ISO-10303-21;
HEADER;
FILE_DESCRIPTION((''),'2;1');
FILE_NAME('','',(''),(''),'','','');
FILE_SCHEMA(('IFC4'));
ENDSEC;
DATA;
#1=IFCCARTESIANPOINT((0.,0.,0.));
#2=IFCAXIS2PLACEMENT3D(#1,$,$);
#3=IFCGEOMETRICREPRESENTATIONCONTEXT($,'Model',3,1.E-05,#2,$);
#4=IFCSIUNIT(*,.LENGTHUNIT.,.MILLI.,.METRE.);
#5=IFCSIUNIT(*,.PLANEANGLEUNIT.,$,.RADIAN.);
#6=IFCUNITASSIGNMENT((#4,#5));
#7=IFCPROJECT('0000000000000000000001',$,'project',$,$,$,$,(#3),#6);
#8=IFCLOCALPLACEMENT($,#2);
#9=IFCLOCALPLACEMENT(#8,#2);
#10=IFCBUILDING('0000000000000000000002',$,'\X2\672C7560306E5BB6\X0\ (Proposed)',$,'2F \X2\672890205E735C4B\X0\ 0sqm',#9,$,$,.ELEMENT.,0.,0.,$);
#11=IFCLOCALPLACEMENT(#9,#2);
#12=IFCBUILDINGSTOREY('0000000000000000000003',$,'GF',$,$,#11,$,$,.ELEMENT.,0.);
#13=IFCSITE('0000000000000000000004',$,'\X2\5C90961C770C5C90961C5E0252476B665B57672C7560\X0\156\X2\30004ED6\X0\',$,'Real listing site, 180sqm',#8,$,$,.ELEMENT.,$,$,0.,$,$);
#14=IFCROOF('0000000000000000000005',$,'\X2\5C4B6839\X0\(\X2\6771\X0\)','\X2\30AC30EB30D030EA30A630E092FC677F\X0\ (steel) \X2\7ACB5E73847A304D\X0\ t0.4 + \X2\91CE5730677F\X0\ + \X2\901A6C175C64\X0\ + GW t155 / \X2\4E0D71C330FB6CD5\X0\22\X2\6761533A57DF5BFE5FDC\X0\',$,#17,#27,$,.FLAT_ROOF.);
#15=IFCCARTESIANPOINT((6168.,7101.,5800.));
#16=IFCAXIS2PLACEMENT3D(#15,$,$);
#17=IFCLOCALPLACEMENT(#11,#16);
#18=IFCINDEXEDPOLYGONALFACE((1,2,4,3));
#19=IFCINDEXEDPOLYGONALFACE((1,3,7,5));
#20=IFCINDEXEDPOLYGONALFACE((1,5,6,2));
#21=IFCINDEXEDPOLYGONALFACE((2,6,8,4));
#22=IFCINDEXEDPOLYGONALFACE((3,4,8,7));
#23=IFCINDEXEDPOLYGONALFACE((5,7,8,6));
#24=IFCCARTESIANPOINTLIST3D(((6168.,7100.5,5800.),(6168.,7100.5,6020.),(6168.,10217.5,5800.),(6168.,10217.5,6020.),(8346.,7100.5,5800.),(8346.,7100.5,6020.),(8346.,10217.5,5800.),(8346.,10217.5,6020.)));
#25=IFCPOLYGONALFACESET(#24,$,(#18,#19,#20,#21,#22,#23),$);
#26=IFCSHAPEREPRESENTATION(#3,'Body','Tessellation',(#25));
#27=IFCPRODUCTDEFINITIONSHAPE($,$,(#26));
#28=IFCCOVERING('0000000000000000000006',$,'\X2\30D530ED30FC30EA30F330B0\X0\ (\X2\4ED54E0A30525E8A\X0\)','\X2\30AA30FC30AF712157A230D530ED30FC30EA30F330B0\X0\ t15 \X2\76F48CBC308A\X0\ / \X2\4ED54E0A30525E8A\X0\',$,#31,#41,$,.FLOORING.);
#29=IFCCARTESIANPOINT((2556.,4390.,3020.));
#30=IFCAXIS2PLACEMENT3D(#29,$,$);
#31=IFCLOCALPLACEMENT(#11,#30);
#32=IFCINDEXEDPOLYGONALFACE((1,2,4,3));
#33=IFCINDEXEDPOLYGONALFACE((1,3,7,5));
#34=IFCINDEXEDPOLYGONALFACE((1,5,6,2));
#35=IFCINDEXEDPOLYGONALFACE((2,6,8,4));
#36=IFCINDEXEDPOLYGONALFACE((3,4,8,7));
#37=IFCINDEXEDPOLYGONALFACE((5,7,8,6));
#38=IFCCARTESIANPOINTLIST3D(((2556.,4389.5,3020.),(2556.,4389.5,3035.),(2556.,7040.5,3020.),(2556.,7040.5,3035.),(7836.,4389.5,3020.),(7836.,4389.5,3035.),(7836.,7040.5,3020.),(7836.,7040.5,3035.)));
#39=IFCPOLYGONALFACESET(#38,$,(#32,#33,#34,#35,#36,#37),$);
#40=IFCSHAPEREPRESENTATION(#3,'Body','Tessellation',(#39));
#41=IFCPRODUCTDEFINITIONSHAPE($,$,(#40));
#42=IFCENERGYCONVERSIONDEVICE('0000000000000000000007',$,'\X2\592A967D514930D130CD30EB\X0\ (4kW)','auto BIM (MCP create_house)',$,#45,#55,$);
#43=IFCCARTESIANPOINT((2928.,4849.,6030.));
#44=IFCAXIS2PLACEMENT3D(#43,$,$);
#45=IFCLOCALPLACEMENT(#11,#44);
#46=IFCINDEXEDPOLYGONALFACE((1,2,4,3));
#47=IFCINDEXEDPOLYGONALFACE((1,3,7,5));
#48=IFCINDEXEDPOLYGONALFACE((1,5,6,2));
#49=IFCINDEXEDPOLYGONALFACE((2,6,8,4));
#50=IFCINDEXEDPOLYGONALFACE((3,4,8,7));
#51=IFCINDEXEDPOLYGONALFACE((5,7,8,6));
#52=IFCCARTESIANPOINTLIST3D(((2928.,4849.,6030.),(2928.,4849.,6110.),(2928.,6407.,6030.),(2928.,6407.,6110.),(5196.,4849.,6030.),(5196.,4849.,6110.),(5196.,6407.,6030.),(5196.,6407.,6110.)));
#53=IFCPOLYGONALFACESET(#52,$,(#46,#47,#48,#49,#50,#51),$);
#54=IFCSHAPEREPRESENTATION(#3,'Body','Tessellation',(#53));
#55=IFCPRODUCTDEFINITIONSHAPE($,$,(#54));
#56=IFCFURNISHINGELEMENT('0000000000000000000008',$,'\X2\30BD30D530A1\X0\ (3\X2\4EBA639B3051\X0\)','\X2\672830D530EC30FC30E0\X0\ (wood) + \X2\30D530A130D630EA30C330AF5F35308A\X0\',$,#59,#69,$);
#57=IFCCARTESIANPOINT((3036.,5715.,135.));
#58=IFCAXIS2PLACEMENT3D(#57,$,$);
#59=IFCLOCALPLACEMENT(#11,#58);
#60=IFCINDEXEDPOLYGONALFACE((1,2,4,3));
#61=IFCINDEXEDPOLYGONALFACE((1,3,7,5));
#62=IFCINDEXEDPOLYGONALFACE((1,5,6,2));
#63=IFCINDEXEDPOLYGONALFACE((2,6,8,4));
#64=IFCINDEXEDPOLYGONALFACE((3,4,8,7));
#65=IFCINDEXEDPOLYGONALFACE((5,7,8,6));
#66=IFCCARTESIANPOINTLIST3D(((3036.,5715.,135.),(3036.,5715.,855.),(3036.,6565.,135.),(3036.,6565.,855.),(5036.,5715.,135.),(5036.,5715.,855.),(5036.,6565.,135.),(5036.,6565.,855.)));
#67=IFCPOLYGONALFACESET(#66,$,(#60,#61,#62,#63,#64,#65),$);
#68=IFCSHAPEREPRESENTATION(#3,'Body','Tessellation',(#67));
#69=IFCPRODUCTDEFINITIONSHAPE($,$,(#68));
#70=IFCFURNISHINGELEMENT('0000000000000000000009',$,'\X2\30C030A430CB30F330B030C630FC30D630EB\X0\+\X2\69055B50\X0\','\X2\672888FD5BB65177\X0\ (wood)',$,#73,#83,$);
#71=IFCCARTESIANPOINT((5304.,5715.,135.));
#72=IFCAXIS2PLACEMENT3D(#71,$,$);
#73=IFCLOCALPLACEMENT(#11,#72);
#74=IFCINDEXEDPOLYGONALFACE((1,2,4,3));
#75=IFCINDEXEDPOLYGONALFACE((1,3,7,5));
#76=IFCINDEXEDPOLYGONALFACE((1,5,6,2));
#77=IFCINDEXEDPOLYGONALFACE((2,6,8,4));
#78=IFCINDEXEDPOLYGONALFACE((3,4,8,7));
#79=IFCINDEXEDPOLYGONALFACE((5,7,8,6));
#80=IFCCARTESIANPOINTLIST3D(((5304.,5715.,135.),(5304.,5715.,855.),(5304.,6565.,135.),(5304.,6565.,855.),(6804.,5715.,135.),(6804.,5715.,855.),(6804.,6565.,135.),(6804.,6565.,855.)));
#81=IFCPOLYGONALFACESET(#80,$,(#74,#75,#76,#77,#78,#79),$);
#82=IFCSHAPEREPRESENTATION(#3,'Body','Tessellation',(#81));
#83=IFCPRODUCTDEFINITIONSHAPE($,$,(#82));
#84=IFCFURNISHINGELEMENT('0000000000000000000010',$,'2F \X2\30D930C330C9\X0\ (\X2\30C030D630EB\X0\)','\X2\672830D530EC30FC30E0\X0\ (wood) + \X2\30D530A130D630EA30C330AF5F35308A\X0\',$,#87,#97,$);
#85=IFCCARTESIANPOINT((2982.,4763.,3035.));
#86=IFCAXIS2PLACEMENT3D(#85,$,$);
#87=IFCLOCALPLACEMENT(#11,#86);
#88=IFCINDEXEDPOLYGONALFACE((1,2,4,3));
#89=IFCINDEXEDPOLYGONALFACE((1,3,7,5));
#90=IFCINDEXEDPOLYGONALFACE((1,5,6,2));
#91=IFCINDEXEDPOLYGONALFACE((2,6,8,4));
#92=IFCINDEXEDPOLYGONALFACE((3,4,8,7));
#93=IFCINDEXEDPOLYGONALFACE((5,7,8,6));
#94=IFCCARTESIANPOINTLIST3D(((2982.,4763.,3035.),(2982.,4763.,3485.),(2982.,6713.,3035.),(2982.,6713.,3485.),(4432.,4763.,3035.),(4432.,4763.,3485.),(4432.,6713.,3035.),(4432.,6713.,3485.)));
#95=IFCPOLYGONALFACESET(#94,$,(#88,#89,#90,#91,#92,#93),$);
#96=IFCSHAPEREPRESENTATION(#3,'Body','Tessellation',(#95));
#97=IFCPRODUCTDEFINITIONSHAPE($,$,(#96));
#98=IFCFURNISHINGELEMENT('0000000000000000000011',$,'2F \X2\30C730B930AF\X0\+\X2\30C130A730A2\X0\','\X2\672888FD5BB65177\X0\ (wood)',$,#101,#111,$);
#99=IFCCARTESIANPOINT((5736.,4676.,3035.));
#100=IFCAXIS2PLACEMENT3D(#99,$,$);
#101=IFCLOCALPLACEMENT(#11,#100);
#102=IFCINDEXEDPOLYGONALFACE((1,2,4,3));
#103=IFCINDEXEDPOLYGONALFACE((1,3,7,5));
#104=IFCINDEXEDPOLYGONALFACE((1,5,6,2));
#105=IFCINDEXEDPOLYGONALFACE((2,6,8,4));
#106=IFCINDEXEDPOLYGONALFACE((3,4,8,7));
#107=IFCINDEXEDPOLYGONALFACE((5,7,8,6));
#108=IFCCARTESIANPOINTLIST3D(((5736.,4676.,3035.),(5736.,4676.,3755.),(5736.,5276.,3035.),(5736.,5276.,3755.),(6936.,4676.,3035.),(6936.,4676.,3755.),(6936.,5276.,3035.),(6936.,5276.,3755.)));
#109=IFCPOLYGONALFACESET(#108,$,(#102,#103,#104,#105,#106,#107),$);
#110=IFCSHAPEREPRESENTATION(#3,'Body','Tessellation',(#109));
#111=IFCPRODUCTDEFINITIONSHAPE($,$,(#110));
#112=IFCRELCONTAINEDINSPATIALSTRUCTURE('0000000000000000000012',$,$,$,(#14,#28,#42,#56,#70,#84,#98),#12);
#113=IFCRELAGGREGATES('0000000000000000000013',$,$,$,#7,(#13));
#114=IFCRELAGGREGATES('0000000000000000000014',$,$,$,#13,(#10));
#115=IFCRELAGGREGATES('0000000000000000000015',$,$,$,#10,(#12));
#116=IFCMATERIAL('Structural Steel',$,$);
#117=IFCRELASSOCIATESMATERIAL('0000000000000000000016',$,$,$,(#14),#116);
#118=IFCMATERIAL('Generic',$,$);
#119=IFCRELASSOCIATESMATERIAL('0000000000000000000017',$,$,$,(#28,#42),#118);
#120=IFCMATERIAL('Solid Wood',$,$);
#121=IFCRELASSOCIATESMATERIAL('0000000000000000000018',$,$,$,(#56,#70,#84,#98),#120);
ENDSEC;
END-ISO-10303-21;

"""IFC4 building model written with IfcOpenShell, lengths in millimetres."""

from ifc_helpers import new_model, si_unit, frame, frame_2d, origin, place, context, project, spatial, rectangle, extrude, material, element, save


model = new_model("IFC4")

# Units and contexts
model_context = context("Model", 3, precision=1e-05, world=origin())
ifc_project = project(units=[si_unit("LENGTHUNIT", "METRE", prefix="MILLI"), si_unit("PLANEANGLEUNIT", "RADIAN")], contexts=[model_context])

# Site, building, storey
site_placement = place(None, origin())
site = spatial("IfcSite", under=ifc_project, at=site_placement, Name="岐阜県岐阜市則武字本畠156　他", ObjectType="Real listing site, 180sqm", CompositionType="ELEMENT", RefElevation=0.0)
building_placement = place(site_placement, origin())
building = spatial("IfcBuilding", under=site, at=building_placement, Name="本畠の家 (Proposed)", ObjectType="2F 木造平屋 0sqm", CompositionType="ELEMENT", ElevationOfRefHeight=0.0, ElevationOfTerrain=0.0)
storey_placement = place(building_placement, origin())
storey = spatial("IfcBuildingStorey", under=building, at=storey_placement, Name="GF", CompositionType="ELEMENT", Elevation=0.0)

# Shared definitions
ifc_material_1 = material(Name="Solid Wood")

# Roof
ifc_material_2 = material(Name="Structural Steel")
roof_1_placement = place(storey_placement, frame((6168.0, 7101.0, 5800.0)))
element("IfcRoof", 1, at=roof_1_placement, inside=storey, material=ifc_material_2, Name="屋根(東)", Description="ガルバリウム鋼板 (steel) 立平葺き t0.4 + 野地板 + 通気層 + GW t155 / 不燃・法22条区域対応", PredefinedType="FLAT_ROOF", context=model_context, shape_type="SweptSolid", body=[
    extrude(rectangle(XDim=2178.0, YDim=3117.0, at=frame_2d((1089.0, 1558.0))), frame((6168.0, 7101.0, 5800.0)), (0.0, 0.0, 1.0), 220.0),
])

# Covering
ifc_material_3 = material(Name="Generic")
covering_placement = place(storey_placement, frame((2556.0, 4390.0, 3020.0)))
element("IfcCovering", 2, at=covering_placement, inside=storey, material=ifc_material_3, Name="フローリング (仕上げ床)", Description="オーク無垢フローリング t15 直貼り / 仕上げ床", PredefinedType="FLOORING", context=model_context, shape_type="SweptSolid", body=[
    extrude(rectangle(XDim=5280.0, YDim=2651.0, at=frame_2d((2640.0, 1325.0))), frame((2556.0, 4390.0, 3020.0)), (0.0, 0.0, 1.0), 15.0),
])

# Energy conversion device
energy_conversion_device_placement = place(storey_placement, frame((2928.0, 4849.0, 6030.0)))
element("IfcEnergyConversionDevice", 3, at=energy_conversion_device_placement, inside=storey, material=ifc_material_3, Name="太陽光パネル (4kW)", Description="auto BIM (MCP create_house)", context=model_context, shape_type="SweptSolid", body=[
    extrude(rectangle(XDim=2268.0, YDim=1558.0, at=frame_2d((1134.0, 779.0))), frame((2928.0, 4849.0, 6030.0)), (0.0, 0.0, 1.0), 80.0),
])

# Furnishing elements
furnishing_1_placement = place(storey_placement, frame((3036.0, 5715.0, 135.0)))
element("IfcFurnishingElement", 4, at=furnishing_1_placement, inside=storey, material=ifc_material_1, Name="ソファ (3人掛け)", Description="木フレーム (wood) + ファブリック張り", context=model_context, shape_type="SweptSolid", body=[
    extrude(rectangle(XDim=2000.0, YDim=850.0, at=frame_2d((1000.0, 425.0))), frame((3036.0, 5715.0, 135.0)), (0.0, 0.0, 1.0), 720.0),
])
furnishing_2_placement = place(storey_placement, frame((5304.0, 5715.0, 135.0)))
element("IfcFurnishingElement", 5, at=furnishing_2_placement, inside=storey, material=ifc_material_1, Name="ダイニングテーブル+椅子", Description="木製家具 (wood)", context=model_context, shape_type="SweptSolid", body=[
    extrude(rectangle(XDim=1500.0, YDim=850.0, at=frame_2d((750.0, 425.0))), frame((5304.0, 5715.0, 135.0)), (0.0, 0.0, 1.0), 720.0),
])
furnishing_3_placement = place(storey_placement, frame((2982.0, 4763.0, 3035.0)))
element("IfcFurnishingElement", 6, at=furnishing_3_placement, inside=storey, material=ifc_material_1, Name="2F ベッド (ダブル)", Description="木フレーム (wood) + ファブリック張り", context=model_context, shape_type="SweptSolid", body=[
    extrude(rectangle(XDim=1450.0, YDim=1950.0, at=frame_2d((725.0, 975.0))), frame((2982.0, 4763.0, 3035.0)), (0.0, 0.0, 1.0), 450.0),
])
furnishing_4_placement = place(storey_placement, frame((5736.0, 4676.0, 3035.0)))
element("IfcFurnishingElement", 7, at=furnishing_4_placement, inside=storey, material=ifc_material_1, Name="2F デスク+チェア", Description="木製家具 (wood)", context=model_context, shape_type="SweptSolid", body=[
    extrude(rectangle(XDim=1200.0, YDim=600.0, at=frame_2d((600.0, 300.0))), frame((5736.0, 4676.0, 3035.0)), (0.0, 0.0, 1.0), 720.0),
])

save(model, "model.ifc")
